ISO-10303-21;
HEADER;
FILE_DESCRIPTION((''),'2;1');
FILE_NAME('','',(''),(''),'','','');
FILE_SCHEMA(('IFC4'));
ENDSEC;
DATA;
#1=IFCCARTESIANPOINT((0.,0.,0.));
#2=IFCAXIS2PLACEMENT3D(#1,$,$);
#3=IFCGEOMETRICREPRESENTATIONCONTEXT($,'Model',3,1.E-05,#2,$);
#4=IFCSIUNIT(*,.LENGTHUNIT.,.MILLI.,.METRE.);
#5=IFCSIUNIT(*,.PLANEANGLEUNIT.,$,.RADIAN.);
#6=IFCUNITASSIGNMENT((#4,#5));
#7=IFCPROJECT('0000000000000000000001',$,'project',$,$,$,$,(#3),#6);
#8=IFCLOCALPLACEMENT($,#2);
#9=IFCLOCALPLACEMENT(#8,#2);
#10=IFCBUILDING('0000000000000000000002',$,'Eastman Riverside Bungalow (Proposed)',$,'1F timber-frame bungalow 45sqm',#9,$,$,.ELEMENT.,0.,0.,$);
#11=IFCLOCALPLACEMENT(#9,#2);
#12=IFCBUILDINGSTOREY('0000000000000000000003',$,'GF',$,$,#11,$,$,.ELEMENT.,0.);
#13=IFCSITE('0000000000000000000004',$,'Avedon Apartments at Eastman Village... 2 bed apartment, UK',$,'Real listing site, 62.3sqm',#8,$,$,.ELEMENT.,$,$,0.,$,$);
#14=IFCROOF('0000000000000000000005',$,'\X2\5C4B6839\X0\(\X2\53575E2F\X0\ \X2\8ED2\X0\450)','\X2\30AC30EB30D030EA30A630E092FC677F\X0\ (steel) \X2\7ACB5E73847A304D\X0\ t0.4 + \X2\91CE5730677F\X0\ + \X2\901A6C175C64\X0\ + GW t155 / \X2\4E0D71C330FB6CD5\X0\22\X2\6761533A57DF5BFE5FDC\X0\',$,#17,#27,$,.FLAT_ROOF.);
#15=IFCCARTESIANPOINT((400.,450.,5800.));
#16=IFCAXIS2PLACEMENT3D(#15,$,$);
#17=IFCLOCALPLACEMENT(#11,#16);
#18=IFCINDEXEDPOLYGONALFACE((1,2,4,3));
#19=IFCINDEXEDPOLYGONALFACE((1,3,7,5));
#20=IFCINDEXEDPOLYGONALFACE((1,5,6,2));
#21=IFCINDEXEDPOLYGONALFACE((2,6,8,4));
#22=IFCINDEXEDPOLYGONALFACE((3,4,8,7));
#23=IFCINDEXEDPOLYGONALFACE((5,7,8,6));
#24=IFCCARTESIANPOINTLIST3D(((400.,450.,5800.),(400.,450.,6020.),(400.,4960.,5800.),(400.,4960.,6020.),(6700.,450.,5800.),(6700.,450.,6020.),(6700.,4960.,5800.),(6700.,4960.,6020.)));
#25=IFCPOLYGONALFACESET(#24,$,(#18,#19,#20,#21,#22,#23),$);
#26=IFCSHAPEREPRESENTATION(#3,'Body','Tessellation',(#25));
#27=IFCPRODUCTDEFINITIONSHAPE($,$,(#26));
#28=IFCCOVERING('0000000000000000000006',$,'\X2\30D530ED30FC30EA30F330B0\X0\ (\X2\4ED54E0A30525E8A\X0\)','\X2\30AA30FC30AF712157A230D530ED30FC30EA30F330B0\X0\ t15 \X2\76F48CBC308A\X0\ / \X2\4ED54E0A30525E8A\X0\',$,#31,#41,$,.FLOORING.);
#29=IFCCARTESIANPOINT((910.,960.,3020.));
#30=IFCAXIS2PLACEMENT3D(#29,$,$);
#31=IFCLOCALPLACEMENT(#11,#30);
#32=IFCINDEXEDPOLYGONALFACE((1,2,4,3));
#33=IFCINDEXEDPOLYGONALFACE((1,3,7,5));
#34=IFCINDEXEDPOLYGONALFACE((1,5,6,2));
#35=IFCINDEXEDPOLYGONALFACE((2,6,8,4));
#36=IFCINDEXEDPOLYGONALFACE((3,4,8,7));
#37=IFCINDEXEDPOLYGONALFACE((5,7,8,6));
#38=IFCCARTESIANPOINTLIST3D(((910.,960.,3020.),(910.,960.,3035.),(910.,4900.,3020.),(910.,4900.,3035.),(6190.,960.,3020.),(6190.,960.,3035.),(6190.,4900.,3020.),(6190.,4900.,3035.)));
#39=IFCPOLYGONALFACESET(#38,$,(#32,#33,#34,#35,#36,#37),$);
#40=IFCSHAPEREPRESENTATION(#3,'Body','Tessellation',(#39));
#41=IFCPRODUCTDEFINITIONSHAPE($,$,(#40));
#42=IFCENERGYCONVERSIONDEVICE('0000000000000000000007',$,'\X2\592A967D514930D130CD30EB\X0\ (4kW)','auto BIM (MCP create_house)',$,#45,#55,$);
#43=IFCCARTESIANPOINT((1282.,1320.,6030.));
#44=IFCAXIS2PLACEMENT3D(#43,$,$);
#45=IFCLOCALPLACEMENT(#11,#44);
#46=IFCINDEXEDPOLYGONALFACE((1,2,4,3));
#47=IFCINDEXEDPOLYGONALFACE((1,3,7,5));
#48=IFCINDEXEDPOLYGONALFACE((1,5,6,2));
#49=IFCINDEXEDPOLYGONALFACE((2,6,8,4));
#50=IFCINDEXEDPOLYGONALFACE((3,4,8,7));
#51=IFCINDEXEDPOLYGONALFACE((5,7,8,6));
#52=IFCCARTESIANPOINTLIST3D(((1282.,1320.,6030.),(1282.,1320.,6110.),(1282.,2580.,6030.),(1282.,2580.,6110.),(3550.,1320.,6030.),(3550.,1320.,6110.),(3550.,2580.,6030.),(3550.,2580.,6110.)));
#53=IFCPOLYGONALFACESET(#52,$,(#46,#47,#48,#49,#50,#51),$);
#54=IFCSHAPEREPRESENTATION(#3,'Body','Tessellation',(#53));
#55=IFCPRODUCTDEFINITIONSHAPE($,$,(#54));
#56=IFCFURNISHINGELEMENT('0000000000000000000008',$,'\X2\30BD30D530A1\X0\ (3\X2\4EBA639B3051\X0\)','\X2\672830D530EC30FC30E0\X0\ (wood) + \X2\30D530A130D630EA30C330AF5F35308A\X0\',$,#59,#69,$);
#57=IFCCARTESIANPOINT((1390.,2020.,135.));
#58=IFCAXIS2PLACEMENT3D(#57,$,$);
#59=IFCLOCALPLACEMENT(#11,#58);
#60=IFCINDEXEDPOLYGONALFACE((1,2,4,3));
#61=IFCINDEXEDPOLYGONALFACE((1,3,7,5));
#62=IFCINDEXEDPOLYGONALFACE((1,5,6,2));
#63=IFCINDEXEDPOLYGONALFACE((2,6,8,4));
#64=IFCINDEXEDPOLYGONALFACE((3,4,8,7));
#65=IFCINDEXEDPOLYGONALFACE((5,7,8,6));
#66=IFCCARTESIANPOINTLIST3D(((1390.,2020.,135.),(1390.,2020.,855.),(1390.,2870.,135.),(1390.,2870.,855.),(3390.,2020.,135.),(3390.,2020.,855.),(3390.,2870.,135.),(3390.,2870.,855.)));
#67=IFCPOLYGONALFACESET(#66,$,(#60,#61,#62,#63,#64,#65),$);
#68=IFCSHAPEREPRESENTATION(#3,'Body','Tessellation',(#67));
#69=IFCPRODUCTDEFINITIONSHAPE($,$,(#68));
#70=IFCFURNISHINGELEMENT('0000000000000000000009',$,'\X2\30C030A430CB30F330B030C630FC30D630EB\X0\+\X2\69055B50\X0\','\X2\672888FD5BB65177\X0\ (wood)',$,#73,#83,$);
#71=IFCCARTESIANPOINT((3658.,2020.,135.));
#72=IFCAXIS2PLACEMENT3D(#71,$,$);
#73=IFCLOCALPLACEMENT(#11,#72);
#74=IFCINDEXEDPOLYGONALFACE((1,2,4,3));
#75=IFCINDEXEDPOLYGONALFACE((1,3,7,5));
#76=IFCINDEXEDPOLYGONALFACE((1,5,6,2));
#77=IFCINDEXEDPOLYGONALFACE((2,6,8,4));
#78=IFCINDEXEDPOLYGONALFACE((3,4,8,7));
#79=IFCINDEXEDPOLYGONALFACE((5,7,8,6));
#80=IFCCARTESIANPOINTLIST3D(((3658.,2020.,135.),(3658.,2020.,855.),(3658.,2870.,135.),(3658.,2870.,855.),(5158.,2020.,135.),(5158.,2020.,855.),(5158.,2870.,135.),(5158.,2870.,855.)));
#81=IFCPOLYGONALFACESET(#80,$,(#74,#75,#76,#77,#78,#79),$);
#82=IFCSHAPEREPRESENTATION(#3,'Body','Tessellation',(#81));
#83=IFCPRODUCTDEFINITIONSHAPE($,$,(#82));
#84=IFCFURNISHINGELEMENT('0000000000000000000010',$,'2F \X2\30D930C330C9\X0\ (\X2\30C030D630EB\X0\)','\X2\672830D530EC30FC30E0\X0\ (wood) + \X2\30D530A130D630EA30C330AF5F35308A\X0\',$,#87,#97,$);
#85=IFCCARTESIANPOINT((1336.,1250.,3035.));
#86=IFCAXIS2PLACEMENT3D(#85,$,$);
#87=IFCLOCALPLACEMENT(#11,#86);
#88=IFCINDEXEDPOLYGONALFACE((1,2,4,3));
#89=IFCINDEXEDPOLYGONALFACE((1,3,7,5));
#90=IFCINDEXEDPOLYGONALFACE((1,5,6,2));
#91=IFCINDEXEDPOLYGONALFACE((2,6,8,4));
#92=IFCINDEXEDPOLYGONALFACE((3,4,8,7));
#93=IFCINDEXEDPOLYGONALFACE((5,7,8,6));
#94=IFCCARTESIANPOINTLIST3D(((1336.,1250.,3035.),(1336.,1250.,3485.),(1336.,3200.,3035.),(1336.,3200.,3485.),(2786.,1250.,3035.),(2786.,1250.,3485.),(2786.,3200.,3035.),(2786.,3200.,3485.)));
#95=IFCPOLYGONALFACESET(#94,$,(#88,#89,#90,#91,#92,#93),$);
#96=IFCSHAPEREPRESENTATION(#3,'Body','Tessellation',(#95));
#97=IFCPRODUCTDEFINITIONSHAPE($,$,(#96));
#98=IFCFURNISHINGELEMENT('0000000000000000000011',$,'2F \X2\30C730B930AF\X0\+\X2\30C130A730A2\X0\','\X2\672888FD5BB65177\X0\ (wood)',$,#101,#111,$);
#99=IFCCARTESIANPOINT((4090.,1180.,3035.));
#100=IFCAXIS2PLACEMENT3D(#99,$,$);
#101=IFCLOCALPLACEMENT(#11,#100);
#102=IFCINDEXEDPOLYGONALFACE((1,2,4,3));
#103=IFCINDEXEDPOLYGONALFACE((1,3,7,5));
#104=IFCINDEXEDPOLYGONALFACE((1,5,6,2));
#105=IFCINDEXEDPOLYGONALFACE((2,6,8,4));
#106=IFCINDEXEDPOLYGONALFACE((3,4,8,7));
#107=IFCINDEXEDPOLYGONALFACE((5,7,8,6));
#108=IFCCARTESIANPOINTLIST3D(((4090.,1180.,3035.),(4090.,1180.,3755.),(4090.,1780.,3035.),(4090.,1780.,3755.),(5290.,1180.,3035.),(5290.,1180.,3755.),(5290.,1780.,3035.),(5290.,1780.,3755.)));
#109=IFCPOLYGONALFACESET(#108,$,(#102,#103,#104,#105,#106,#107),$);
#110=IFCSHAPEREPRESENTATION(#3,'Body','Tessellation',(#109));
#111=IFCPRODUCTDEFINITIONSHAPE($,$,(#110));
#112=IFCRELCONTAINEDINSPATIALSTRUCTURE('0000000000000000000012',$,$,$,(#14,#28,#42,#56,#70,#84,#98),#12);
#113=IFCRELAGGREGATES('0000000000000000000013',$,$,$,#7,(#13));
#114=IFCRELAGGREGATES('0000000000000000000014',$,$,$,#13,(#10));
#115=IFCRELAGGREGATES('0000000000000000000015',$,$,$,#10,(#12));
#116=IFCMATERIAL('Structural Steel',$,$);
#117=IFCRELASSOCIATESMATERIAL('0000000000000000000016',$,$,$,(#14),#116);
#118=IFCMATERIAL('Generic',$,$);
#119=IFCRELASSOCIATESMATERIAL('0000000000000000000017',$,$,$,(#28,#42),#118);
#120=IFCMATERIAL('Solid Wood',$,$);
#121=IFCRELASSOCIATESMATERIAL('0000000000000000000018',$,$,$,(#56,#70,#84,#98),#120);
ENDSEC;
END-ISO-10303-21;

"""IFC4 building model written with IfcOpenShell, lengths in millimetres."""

from ifc_helpers import new_model, si_unit, frame, frame_2d, origin, place, context, project, spatial, rectangle, extrude, material, element, save


model = new_model("IFC4")

# Units and contexts
model_context = context("Model", 3, precision=1e-05, world=origin())
ifc_project = project(units=[si_unit("LENGTHUNIT", "METRE", prefix="MILLI"), si_unit("PLANEANGLEUNIT", "RADIAN")], contexts=[model_context])

# Site, building, storey
site_placement = place(None, origin())
site = spatial("IfcSite", under=ifc_project, at=site_placement, Name="Avedon Apartments at Eastman Village... 2 bed apartment, UK", ObjectType="Real listing site, 62.3sqm", CompositionType="ELEMENT", RefElevation=0.0)
building_placement = place(site_placement, origin())
building = spatial("IfcBuilding", under=site, at=building_placement, Name="Eastman Riverside Bungalow (Proposed)", ObjectType="1F timber-frame bungalow 45sqm", CompositionType="ELEMENT", ElevationOfRefHeight=0.0, ElevationOfTerrain=0.0)
storey_placement = place(building_placement, origin())
storey = spatial("IfcBuildingStorey", under=building, at=storey_placement, Name="GF", CompositionType="ELEMENT", Elevation=0.0)

# Shared definitions
ifc_material_1 = material(Name="Solid Wood")

# Shared definitions
ifc_material_2 = material(Name="Generic")

# Roof
ifc_material_3 = material(Name="Structural Steel")
for number, where, name in (
    (1, (400.0, 450.0, 5800.0), "屋根(南帯 軒450)"),
):
    element("IfcRoof", number, at=place(storey_placement, frame(where)), inside=storey, material=ifc_material_3, Name=name, Description="ガルバリウム鋼板 (steel) 立平葺き t0.4 + 野地板 + 通気層 + GW t155 / 不燃・法22条区域対応", PredefinedType="FLAT_ROOF", context=model_context, shape_type="SweptSolid", body=[
        extrude(rectangle(XDim=6300.0, YDim=4510.0, at=frame_2d((3150.0, 2255.0))), frame((400.0, 450.0, 5800.0)), (0.0, 0.0, 1.0), 220.0),
    ])

# Covering
covering_placement = place(storey_placement, frame((910.0, 960.0, 3020.0)))
element("IfcCovering", 2, at=covering_placement, inside=storey, material=ifc_material_2, Name="フローリング (仕上げ床)", Description="オーク無垢フローリング t15 直貼り / 仕上げ床", PredefinedType="FLOORING", context=model_context, shape_type="SweptSolid", body=[
    extrude(rectangle(XDim=5280.0, YDim=3940.0, at=frame_2d((2640.0, 1970.0))), frame((910.0, 960.0, 3020.0)), (0.0, 0.0, 1.0), 15.0),
])

# Energy conversion device
energy_conversion_device_placement = place(storey_placement, frame((1282.0, 1320.0, 6030.0)))
element("IfcEnergyConversionDevice", 3, at=energy_conversion_device_placement, inside=storey, material=ifc_material_2, Name="太陽光パネル (4kW)", Description="auto BIM (MCP create_house)", context=model_context, shape_type="SweptSolid", body=[
    extrude(rectangle(XDim=2268.0, YDim=1260.0, at=frame_2d((1134.0, 630.0))), frame((1282.0, 1320.0, 6030.0)), (0.0, 0.0, 1.0), 80.0),
])

# Furnishing elements
furnishing_1_placement = place(storey_placement, frame((1390.0, 2020.0, 135.0)))
element("IfcFurnishingElement", 4, at=furnishing_1_placement, inside=storey, material=ifc_material_1, Name="ソファ (3人掛け)", Description="木フレーム (wood) + ファブリック張り", context=model_context, shape_type="SweptSolid", body=[
    extrude(rectangle(XDim=2000.0, YDim=850.0, at=frame_2d((1000.0, 425.0))), frame((1390.0, 2020.0, 135.0)), (0.0, 0.0, 1.0), 720.0),
])
furnishing_2_placement = place(storey_placement, frame((3658.0, 2020.0, 135.0)))
element("IfcFurnishingElement", 5, at=furnishing_2_placement, inside=storey, material=ifc_material_1, Name="ダイニングテーブル+椅子", Description="木製家具 (wood)", context=model_context, shape_type="SweptSolid", body=[
    extrude(rectangle(XDim=1500.0, YDim=850.0, at=frame_2d((750.0, 425.0))), frame((3658.0, 2020.0, 135.0)), (0.0, 0.0, 1.0), 720.0),
])
furnishing_3_placement = place(storey_placement, frame((1336.0, 1250.0, 3035.0)))
element("IfcFurnishingElement", 6, at=furnishing_3_placement, inside=storey, material=ifc_material_1, Name="2F ベッド (ダブル)", Description="木フレーム (wood) + ファブリック張り", context=model_context, shape_type="SweptSolid", body=[
    extrude(rectangle(XDim=1450.0, YDim=1950.0, at=frame_2d((725.0, 975.0))), frame((1336.0, 1250.0, 3035.0)), (0.0, 0.0, 1.0), 450.0),
])
furnishing_4_placement = place(storey_placement, frame((4090.0, 1180.0, 3035.0)))
element("IfcFurnishingElement", 7, at=furnishing_4_placement, inside=storey, material=ifc_material_1, Name="2F デスク+チェア", Description="木製家具 (wood)", context=model_context, shape_type="SweptSolid", body=[
    extrude(rectangle(XDim=1200.0, YDim=600.0, at=frame_2d((600.0, 300.0))), frame((4090.0, 1180.0, 3035.0)), (0.0, 0.0, 1.0), 720.0),
])

save(model, "model.ifc")
